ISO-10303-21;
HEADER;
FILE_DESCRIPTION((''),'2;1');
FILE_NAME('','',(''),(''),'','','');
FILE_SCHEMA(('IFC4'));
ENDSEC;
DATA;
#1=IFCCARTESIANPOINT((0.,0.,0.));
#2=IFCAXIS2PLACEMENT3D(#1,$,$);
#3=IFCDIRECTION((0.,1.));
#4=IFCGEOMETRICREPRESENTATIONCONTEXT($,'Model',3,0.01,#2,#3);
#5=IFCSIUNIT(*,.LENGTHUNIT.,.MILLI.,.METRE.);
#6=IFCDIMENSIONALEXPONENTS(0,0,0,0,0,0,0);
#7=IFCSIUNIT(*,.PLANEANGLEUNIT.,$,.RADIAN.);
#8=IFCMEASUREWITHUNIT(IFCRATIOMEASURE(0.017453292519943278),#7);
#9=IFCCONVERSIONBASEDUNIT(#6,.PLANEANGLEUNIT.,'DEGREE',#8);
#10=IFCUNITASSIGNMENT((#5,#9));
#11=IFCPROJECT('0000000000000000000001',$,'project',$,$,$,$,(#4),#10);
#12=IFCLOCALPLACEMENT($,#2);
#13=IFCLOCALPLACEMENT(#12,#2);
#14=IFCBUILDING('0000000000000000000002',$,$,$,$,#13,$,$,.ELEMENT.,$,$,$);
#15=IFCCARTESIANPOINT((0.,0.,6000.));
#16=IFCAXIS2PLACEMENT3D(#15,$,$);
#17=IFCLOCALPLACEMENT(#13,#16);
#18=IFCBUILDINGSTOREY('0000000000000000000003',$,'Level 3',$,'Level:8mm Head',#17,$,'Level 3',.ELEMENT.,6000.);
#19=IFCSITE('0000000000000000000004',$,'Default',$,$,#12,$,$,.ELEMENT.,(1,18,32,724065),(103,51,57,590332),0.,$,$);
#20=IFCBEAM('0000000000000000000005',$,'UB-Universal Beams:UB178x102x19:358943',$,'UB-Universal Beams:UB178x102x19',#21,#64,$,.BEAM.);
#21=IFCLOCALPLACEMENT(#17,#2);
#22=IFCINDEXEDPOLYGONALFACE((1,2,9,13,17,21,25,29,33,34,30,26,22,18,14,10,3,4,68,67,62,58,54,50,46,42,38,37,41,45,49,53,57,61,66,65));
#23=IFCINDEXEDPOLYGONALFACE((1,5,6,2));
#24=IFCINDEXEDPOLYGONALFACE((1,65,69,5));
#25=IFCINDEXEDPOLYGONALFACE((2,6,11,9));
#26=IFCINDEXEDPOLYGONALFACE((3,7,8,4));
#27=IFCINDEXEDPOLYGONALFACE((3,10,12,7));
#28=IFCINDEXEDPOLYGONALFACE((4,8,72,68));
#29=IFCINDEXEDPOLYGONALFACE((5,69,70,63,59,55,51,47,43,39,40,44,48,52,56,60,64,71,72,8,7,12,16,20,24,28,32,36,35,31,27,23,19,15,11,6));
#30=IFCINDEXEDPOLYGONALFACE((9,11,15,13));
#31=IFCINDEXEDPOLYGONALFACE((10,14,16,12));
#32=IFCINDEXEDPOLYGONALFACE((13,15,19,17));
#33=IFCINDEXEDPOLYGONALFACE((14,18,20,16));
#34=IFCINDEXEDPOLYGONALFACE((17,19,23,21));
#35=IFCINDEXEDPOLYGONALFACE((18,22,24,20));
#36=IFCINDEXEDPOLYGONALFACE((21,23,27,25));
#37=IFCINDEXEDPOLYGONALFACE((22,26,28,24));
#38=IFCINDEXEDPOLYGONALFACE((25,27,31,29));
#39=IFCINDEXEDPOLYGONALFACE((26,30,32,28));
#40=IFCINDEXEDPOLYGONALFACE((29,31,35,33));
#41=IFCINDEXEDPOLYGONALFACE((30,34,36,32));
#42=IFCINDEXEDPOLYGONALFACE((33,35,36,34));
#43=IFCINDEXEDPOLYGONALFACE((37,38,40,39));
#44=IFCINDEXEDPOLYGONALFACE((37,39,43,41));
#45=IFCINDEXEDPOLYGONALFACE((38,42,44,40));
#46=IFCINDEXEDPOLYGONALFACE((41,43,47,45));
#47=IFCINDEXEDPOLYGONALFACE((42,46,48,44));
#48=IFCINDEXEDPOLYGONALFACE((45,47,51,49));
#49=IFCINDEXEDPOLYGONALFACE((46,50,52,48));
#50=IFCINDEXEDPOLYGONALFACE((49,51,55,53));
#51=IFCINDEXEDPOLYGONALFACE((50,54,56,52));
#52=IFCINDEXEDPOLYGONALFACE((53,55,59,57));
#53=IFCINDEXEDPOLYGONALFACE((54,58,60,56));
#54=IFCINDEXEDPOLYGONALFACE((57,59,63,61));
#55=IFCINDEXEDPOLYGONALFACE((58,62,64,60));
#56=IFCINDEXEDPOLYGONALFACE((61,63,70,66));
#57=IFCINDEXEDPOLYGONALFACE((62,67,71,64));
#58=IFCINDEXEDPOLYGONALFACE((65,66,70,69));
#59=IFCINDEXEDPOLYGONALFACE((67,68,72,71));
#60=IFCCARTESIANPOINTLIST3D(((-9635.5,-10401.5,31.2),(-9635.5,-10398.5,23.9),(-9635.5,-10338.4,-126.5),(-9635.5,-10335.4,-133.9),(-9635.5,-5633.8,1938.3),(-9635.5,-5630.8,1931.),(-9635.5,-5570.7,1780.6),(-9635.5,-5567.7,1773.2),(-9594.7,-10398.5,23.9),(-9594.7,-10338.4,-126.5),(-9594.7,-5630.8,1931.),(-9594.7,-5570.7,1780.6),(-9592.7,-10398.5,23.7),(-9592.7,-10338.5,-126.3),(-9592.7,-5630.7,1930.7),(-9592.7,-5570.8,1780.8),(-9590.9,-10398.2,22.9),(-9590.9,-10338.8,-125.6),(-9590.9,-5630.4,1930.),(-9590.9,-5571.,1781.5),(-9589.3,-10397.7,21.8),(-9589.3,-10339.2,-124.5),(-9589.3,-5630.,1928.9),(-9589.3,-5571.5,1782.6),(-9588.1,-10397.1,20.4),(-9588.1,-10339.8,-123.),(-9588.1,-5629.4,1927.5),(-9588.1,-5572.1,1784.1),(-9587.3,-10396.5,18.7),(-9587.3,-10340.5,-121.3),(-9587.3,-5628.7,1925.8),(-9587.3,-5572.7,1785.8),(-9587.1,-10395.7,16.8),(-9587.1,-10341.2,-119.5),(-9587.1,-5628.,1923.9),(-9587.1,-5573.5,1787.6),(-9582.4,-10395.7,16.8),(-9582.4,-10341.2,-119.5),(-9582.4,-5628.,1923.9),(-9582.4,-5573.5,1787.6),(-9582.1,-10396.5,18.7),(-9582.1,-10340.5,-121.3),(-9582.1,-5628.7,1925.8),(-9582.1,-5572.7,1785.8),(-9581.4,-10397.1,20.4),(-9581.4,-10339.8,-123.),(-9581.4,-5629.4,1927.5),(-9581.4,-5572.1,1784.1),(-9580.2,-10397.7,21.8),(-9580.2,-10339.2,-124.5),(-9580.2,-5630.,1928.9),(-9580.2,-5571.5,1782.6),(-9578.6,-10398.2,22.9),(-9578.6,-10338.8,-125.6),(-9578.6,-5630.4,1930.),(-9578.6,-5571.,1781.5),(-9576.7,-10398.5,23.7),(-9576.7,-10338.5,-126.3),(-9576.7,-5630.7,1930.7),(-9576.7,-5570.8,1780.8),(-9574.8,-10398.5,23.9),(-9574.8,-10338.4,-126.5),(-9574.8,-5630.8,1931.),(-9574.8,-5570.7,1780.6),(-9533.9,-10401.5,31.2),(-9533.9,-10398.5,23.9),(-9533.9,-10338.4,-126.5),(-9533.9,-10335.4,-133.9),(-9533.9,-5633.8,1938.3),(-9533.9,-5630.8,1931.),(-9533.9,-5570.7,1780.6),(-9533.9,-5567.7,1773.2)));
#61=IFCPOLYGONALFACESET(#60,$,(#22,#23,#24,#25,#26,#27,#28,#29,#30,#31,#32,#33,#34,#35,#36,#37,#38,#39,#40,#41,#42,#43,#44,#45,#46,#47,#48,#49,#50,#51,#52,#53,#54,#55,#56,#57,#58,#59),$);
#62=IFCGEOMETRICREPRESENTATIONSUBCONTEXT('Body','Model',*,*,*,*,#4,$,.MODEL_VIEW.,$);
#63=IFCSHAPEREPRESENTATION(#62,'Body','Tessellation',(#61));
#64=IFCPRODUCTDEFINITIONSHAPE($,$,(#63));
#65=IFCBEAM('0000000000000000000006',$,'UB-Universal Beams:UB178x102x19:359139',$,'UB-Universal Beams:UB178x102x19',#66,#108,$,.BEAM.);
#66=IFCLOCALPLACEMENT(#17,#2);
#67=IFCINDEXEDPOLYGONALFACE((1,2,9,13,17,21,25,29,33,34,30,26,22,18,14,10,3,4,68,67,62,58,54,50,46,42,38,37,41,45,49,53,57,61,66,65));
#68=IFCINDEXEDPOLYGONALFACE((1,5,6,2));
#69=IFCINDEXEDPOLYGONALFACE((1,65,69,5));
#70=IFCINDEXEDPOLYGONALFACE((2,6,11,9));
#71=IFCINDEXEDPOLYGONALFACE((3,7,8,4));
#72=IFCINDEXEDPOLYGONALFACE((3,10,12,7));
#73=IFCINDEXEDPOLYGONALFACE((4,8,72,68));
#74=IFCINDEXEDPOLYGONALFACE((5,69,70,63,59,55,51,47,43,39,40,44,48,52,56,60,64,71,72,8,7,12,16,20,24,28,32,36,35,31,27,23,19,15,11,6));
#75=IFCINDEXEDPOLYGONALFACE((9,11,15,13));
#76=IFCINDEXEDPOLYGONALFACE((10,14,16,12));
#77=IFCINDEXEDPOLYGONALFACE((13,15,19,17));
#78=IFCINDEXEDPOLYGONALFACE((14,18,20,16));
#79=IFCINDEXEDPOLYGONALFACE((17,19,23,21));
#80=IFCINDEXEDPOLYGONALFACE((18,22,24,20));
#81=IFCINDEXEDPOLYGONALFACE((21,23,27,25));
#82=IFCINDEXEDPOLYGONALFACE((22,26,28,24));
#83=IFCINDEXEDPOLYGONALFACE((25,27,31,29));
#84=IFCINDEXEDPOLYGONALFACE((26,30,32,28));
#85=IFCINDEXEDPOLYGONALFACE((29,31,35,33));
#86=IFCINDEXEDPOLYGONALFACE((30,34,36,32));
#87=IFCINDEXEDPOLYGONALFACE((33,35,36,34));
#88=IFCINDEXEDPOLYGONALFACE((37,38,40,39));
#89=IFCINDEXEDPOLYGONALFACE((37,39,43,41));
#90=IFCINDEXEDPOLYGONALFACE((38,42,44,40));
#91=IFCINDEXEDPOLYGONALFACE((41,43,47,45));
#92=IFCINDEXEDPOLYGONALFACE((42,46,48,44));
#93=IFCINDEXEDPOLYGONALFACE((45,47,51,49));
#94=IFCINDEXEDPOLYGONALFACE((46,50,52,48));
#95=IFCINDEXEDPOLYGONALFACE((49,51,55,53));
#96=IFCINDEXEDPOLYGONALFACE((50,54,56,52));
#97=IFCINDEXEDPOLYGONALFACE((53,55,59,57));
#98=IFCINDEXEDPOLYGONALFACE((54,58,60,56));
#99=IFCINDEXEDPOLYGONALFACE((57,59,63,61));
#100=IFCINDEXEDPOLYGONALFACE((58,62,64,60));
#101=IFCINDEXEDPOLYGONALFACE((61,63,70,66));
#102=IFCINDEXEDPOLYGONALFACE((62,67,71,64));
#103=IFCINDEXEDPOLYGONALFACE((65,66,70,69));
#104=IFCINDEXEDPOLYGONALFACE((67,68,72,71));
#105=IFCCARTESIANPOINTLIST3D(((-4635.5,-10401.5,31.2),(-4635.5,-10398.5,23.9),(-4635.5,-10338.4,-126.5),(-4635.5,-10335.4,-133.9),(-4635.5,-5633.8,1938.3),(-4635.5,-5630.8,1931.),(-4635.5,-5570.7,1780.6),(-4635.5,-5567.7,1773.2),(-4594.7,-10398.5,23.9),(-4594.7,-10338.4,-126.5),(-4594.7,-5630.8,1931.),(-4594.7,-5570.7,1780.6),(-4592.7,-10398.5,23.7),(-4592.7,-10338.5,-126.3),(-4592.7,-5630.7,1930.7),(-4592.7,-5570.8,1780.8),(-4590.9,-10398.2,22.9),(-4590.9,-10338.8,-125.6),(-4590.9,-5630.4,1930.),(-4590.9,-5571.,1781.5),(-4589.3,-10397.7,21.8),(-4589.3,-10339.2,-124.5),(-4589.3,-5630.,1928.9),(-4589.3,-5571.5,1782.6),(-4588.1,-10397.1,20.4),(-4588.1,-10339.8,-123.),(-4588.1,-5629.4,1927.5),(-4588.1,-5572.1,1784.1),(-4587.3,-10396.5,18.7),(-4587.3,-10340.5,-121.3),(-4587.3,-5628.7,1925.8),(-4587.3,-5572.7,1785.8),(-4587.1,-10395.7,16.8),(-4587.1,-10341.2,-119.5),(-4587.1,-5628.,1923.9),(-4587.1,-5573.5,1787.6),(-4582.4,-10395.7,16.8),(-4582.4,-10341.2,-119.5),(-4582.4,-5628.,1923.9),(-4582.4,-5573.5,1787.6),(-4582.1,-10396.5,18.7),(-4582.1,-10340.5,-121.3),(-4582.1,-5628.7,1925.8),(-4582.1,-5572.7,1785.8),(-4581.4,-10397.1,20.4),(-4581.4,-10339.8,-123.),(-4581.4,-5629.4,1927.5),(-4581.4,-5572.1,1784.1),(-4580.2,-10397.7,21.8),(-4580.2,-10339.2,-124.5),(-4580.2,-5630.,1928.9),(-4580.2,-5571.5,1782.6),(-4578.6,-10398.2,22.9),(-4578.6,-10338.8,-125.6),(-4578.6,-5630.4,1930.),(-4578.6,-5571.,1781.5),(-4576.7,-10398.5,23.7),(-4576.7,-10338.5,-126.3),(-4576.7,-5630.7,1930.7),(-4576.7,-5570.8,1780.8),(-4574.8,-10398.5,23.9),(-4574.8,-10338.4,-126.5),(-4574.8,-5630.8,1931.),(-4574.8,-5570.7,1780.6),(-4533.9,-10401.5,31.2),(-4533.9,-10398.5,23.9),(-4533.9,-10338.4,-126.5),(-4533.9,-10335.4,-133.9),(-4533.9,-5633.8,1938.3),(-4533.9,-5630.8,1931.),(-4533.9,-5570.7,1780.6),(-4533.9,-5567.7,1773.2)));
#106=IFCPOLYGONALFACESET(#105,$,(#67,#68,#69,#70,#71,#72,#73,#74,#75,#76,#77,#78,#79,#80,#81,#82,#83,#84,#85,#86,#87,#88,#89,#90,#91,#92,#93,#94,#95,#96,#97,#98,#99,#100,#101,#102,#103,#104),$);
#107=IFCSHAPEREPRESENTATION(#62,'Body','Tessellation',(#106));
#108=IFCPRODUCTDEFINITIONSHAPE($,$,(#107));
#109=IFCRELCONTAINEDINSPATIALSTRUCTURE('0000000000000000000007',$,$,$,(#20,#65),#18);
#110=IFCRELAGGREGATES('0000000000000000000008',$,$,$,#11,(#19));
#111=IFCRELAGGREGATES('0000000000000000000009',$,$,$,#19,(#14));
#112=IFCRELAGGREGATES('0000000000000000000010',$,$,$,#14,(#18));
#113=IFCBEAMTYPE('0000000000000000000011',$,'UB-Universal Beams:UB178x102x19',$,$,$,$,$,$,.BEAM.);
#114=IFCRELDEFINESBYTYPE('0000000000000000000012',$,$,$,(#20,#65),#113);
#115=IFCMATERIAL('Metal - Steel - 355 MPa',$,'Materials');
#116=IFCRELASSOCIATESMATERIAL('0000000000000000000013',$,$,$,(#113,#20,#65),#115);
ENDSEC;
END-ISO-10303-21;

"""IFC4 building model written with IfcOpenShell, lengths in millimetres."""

from ifc_helpers import new_model, entity, si_unit, converted_unit, direction, frame, origin, place, context, subcontext, project, spatial, line, arc, indexed_curve, outline, extrude, source, transform, mapped, material, type_object, type_shapes, element, save


model = new_model("IFC4")

# Units and contexts
model_context = context("Model", 3, precision=0.01, world=origin(), true_north=direction((0.0, 1.0)))
body_context = subcontext(model_context, "Body", "Model", "MODEL_VIEW")
ifc_project = project(units=[si_unit("LENGTHUNIT", "METRE", prefix="MILLI"), converted_unit("PLANEANGLEUNIT", "DEGREE", entity("IfcRatioMeasure", 0.017453292519943278), si_unit("PLANEANGLEUNIT", "RADIAN"), dimensions=[0, 0, 0, 0, 0, 0, 0])], contexts=[model_context])

# Site, building, storey
site_placement = place(None, origin())
site = spatial("IfcSite", under=ifc_project, at=site_placement, Name="Default", CompositionType="ELEMENT", RefLatitude=(1, 18, 32, 724065), RefLongitude=(103, 51, 57, 590332), RefElevation=0.0)
building_placement = place(site_placement, origin())
building = spatial("IfcBuilding", under=site, at=building_placement, CompositionType="ELEMENT")
storey_placement = place(building_placement, frame((0.0, 0.0, 6000.0)))
storey = spatial("IfcBuildingStorey", under=building, at=storey_placement, Name="Level 3", ObjectType="Level:8mm Head", LongName="Level 3", CompositionType="ELEMENT", Elevation=6000.0)

# Shared definitions
ifc_material = material(Name="Metal - Steel - 355 MPa", Category="Materials")

# Beams
beam_type_1 = type_object("IfcBeamType", Name="UB-Universal Beams:UB178x102x19", PredefinedType="BEAM", material=ifc_material)
shared_shape_1 = source(origin(), body_context, "Body", "SweptSolid", [
    extrude(outline(indexed_curve([(-88.9, -50.8), (-81.0, -50.8), (-81.0, -9.9), (-78.8, -4.6), (-73.4, -2.3), (73.4, -2.3), (78.8, -4.6), (81.0, -9.9), (81.0, -50.8), (88.9, -50.8), (88.9, 50.8), (81.0, 50.8), (81.0, 10.0), (78.8, 4.6), (73.4, 2.4), (-73.4, 2.4), (-78.8, 4.6), (-81.0, 10.0), (-81.0, 50.8), (-88.9, 50.8)], segments=[line(1, 2, 3), arc(3, 4, 5), line(5, 6), arc(6, 7, 8), line(8, 9, 10, 11, 12, 13), arc(13, 14, 15), line(15, 16), arc(16, 17, 18), line(18, 19, 20, 1)], self_intersect=False)), frame((-2608.5, 0.0, 0.0), z_axis=(1.0, 0.0, 0.0), x_axis=(0.0, 0.0, -1.0)), (0.0, 0.0, 1.0), 5135.0),
])
type_shapes(beam_type_1, [shared_shape_1])
for number, where, z_axis, x_axis, name in (
    (1, (-9584.7, -7946.5, 917.5), (0.0, -0.371391, 0.928477), (0.0, 0.928477, 0.371391), "UB-Universal Beams:UB178x102x19:358943"),
    (2, (-4584.7, -7946.5, 917.5), (0.0, -0.371391, 0.928477), (0.0, 0.928477, 0.371391), "UB-Universal Beams:UB178x102x19:359139"),
):
    element("IfcBeam", number, at=place(storey_placement, frame(where, z_axis=z_axis, x_axis=x_axis)), inside=storey, type_object=beam_type_1, material=ifc_material, Name=name, ObjectType="UB-Universal Beams:UB178x102x19", PredefinedType="BEAM", context=body_context, shape_type="MappedRepresentation", body=[
        mapped(shared_shape_1, transform((0.0, 0.0, 0.0), scale=1.0)),
    ])

save(model, "model.ifc")
